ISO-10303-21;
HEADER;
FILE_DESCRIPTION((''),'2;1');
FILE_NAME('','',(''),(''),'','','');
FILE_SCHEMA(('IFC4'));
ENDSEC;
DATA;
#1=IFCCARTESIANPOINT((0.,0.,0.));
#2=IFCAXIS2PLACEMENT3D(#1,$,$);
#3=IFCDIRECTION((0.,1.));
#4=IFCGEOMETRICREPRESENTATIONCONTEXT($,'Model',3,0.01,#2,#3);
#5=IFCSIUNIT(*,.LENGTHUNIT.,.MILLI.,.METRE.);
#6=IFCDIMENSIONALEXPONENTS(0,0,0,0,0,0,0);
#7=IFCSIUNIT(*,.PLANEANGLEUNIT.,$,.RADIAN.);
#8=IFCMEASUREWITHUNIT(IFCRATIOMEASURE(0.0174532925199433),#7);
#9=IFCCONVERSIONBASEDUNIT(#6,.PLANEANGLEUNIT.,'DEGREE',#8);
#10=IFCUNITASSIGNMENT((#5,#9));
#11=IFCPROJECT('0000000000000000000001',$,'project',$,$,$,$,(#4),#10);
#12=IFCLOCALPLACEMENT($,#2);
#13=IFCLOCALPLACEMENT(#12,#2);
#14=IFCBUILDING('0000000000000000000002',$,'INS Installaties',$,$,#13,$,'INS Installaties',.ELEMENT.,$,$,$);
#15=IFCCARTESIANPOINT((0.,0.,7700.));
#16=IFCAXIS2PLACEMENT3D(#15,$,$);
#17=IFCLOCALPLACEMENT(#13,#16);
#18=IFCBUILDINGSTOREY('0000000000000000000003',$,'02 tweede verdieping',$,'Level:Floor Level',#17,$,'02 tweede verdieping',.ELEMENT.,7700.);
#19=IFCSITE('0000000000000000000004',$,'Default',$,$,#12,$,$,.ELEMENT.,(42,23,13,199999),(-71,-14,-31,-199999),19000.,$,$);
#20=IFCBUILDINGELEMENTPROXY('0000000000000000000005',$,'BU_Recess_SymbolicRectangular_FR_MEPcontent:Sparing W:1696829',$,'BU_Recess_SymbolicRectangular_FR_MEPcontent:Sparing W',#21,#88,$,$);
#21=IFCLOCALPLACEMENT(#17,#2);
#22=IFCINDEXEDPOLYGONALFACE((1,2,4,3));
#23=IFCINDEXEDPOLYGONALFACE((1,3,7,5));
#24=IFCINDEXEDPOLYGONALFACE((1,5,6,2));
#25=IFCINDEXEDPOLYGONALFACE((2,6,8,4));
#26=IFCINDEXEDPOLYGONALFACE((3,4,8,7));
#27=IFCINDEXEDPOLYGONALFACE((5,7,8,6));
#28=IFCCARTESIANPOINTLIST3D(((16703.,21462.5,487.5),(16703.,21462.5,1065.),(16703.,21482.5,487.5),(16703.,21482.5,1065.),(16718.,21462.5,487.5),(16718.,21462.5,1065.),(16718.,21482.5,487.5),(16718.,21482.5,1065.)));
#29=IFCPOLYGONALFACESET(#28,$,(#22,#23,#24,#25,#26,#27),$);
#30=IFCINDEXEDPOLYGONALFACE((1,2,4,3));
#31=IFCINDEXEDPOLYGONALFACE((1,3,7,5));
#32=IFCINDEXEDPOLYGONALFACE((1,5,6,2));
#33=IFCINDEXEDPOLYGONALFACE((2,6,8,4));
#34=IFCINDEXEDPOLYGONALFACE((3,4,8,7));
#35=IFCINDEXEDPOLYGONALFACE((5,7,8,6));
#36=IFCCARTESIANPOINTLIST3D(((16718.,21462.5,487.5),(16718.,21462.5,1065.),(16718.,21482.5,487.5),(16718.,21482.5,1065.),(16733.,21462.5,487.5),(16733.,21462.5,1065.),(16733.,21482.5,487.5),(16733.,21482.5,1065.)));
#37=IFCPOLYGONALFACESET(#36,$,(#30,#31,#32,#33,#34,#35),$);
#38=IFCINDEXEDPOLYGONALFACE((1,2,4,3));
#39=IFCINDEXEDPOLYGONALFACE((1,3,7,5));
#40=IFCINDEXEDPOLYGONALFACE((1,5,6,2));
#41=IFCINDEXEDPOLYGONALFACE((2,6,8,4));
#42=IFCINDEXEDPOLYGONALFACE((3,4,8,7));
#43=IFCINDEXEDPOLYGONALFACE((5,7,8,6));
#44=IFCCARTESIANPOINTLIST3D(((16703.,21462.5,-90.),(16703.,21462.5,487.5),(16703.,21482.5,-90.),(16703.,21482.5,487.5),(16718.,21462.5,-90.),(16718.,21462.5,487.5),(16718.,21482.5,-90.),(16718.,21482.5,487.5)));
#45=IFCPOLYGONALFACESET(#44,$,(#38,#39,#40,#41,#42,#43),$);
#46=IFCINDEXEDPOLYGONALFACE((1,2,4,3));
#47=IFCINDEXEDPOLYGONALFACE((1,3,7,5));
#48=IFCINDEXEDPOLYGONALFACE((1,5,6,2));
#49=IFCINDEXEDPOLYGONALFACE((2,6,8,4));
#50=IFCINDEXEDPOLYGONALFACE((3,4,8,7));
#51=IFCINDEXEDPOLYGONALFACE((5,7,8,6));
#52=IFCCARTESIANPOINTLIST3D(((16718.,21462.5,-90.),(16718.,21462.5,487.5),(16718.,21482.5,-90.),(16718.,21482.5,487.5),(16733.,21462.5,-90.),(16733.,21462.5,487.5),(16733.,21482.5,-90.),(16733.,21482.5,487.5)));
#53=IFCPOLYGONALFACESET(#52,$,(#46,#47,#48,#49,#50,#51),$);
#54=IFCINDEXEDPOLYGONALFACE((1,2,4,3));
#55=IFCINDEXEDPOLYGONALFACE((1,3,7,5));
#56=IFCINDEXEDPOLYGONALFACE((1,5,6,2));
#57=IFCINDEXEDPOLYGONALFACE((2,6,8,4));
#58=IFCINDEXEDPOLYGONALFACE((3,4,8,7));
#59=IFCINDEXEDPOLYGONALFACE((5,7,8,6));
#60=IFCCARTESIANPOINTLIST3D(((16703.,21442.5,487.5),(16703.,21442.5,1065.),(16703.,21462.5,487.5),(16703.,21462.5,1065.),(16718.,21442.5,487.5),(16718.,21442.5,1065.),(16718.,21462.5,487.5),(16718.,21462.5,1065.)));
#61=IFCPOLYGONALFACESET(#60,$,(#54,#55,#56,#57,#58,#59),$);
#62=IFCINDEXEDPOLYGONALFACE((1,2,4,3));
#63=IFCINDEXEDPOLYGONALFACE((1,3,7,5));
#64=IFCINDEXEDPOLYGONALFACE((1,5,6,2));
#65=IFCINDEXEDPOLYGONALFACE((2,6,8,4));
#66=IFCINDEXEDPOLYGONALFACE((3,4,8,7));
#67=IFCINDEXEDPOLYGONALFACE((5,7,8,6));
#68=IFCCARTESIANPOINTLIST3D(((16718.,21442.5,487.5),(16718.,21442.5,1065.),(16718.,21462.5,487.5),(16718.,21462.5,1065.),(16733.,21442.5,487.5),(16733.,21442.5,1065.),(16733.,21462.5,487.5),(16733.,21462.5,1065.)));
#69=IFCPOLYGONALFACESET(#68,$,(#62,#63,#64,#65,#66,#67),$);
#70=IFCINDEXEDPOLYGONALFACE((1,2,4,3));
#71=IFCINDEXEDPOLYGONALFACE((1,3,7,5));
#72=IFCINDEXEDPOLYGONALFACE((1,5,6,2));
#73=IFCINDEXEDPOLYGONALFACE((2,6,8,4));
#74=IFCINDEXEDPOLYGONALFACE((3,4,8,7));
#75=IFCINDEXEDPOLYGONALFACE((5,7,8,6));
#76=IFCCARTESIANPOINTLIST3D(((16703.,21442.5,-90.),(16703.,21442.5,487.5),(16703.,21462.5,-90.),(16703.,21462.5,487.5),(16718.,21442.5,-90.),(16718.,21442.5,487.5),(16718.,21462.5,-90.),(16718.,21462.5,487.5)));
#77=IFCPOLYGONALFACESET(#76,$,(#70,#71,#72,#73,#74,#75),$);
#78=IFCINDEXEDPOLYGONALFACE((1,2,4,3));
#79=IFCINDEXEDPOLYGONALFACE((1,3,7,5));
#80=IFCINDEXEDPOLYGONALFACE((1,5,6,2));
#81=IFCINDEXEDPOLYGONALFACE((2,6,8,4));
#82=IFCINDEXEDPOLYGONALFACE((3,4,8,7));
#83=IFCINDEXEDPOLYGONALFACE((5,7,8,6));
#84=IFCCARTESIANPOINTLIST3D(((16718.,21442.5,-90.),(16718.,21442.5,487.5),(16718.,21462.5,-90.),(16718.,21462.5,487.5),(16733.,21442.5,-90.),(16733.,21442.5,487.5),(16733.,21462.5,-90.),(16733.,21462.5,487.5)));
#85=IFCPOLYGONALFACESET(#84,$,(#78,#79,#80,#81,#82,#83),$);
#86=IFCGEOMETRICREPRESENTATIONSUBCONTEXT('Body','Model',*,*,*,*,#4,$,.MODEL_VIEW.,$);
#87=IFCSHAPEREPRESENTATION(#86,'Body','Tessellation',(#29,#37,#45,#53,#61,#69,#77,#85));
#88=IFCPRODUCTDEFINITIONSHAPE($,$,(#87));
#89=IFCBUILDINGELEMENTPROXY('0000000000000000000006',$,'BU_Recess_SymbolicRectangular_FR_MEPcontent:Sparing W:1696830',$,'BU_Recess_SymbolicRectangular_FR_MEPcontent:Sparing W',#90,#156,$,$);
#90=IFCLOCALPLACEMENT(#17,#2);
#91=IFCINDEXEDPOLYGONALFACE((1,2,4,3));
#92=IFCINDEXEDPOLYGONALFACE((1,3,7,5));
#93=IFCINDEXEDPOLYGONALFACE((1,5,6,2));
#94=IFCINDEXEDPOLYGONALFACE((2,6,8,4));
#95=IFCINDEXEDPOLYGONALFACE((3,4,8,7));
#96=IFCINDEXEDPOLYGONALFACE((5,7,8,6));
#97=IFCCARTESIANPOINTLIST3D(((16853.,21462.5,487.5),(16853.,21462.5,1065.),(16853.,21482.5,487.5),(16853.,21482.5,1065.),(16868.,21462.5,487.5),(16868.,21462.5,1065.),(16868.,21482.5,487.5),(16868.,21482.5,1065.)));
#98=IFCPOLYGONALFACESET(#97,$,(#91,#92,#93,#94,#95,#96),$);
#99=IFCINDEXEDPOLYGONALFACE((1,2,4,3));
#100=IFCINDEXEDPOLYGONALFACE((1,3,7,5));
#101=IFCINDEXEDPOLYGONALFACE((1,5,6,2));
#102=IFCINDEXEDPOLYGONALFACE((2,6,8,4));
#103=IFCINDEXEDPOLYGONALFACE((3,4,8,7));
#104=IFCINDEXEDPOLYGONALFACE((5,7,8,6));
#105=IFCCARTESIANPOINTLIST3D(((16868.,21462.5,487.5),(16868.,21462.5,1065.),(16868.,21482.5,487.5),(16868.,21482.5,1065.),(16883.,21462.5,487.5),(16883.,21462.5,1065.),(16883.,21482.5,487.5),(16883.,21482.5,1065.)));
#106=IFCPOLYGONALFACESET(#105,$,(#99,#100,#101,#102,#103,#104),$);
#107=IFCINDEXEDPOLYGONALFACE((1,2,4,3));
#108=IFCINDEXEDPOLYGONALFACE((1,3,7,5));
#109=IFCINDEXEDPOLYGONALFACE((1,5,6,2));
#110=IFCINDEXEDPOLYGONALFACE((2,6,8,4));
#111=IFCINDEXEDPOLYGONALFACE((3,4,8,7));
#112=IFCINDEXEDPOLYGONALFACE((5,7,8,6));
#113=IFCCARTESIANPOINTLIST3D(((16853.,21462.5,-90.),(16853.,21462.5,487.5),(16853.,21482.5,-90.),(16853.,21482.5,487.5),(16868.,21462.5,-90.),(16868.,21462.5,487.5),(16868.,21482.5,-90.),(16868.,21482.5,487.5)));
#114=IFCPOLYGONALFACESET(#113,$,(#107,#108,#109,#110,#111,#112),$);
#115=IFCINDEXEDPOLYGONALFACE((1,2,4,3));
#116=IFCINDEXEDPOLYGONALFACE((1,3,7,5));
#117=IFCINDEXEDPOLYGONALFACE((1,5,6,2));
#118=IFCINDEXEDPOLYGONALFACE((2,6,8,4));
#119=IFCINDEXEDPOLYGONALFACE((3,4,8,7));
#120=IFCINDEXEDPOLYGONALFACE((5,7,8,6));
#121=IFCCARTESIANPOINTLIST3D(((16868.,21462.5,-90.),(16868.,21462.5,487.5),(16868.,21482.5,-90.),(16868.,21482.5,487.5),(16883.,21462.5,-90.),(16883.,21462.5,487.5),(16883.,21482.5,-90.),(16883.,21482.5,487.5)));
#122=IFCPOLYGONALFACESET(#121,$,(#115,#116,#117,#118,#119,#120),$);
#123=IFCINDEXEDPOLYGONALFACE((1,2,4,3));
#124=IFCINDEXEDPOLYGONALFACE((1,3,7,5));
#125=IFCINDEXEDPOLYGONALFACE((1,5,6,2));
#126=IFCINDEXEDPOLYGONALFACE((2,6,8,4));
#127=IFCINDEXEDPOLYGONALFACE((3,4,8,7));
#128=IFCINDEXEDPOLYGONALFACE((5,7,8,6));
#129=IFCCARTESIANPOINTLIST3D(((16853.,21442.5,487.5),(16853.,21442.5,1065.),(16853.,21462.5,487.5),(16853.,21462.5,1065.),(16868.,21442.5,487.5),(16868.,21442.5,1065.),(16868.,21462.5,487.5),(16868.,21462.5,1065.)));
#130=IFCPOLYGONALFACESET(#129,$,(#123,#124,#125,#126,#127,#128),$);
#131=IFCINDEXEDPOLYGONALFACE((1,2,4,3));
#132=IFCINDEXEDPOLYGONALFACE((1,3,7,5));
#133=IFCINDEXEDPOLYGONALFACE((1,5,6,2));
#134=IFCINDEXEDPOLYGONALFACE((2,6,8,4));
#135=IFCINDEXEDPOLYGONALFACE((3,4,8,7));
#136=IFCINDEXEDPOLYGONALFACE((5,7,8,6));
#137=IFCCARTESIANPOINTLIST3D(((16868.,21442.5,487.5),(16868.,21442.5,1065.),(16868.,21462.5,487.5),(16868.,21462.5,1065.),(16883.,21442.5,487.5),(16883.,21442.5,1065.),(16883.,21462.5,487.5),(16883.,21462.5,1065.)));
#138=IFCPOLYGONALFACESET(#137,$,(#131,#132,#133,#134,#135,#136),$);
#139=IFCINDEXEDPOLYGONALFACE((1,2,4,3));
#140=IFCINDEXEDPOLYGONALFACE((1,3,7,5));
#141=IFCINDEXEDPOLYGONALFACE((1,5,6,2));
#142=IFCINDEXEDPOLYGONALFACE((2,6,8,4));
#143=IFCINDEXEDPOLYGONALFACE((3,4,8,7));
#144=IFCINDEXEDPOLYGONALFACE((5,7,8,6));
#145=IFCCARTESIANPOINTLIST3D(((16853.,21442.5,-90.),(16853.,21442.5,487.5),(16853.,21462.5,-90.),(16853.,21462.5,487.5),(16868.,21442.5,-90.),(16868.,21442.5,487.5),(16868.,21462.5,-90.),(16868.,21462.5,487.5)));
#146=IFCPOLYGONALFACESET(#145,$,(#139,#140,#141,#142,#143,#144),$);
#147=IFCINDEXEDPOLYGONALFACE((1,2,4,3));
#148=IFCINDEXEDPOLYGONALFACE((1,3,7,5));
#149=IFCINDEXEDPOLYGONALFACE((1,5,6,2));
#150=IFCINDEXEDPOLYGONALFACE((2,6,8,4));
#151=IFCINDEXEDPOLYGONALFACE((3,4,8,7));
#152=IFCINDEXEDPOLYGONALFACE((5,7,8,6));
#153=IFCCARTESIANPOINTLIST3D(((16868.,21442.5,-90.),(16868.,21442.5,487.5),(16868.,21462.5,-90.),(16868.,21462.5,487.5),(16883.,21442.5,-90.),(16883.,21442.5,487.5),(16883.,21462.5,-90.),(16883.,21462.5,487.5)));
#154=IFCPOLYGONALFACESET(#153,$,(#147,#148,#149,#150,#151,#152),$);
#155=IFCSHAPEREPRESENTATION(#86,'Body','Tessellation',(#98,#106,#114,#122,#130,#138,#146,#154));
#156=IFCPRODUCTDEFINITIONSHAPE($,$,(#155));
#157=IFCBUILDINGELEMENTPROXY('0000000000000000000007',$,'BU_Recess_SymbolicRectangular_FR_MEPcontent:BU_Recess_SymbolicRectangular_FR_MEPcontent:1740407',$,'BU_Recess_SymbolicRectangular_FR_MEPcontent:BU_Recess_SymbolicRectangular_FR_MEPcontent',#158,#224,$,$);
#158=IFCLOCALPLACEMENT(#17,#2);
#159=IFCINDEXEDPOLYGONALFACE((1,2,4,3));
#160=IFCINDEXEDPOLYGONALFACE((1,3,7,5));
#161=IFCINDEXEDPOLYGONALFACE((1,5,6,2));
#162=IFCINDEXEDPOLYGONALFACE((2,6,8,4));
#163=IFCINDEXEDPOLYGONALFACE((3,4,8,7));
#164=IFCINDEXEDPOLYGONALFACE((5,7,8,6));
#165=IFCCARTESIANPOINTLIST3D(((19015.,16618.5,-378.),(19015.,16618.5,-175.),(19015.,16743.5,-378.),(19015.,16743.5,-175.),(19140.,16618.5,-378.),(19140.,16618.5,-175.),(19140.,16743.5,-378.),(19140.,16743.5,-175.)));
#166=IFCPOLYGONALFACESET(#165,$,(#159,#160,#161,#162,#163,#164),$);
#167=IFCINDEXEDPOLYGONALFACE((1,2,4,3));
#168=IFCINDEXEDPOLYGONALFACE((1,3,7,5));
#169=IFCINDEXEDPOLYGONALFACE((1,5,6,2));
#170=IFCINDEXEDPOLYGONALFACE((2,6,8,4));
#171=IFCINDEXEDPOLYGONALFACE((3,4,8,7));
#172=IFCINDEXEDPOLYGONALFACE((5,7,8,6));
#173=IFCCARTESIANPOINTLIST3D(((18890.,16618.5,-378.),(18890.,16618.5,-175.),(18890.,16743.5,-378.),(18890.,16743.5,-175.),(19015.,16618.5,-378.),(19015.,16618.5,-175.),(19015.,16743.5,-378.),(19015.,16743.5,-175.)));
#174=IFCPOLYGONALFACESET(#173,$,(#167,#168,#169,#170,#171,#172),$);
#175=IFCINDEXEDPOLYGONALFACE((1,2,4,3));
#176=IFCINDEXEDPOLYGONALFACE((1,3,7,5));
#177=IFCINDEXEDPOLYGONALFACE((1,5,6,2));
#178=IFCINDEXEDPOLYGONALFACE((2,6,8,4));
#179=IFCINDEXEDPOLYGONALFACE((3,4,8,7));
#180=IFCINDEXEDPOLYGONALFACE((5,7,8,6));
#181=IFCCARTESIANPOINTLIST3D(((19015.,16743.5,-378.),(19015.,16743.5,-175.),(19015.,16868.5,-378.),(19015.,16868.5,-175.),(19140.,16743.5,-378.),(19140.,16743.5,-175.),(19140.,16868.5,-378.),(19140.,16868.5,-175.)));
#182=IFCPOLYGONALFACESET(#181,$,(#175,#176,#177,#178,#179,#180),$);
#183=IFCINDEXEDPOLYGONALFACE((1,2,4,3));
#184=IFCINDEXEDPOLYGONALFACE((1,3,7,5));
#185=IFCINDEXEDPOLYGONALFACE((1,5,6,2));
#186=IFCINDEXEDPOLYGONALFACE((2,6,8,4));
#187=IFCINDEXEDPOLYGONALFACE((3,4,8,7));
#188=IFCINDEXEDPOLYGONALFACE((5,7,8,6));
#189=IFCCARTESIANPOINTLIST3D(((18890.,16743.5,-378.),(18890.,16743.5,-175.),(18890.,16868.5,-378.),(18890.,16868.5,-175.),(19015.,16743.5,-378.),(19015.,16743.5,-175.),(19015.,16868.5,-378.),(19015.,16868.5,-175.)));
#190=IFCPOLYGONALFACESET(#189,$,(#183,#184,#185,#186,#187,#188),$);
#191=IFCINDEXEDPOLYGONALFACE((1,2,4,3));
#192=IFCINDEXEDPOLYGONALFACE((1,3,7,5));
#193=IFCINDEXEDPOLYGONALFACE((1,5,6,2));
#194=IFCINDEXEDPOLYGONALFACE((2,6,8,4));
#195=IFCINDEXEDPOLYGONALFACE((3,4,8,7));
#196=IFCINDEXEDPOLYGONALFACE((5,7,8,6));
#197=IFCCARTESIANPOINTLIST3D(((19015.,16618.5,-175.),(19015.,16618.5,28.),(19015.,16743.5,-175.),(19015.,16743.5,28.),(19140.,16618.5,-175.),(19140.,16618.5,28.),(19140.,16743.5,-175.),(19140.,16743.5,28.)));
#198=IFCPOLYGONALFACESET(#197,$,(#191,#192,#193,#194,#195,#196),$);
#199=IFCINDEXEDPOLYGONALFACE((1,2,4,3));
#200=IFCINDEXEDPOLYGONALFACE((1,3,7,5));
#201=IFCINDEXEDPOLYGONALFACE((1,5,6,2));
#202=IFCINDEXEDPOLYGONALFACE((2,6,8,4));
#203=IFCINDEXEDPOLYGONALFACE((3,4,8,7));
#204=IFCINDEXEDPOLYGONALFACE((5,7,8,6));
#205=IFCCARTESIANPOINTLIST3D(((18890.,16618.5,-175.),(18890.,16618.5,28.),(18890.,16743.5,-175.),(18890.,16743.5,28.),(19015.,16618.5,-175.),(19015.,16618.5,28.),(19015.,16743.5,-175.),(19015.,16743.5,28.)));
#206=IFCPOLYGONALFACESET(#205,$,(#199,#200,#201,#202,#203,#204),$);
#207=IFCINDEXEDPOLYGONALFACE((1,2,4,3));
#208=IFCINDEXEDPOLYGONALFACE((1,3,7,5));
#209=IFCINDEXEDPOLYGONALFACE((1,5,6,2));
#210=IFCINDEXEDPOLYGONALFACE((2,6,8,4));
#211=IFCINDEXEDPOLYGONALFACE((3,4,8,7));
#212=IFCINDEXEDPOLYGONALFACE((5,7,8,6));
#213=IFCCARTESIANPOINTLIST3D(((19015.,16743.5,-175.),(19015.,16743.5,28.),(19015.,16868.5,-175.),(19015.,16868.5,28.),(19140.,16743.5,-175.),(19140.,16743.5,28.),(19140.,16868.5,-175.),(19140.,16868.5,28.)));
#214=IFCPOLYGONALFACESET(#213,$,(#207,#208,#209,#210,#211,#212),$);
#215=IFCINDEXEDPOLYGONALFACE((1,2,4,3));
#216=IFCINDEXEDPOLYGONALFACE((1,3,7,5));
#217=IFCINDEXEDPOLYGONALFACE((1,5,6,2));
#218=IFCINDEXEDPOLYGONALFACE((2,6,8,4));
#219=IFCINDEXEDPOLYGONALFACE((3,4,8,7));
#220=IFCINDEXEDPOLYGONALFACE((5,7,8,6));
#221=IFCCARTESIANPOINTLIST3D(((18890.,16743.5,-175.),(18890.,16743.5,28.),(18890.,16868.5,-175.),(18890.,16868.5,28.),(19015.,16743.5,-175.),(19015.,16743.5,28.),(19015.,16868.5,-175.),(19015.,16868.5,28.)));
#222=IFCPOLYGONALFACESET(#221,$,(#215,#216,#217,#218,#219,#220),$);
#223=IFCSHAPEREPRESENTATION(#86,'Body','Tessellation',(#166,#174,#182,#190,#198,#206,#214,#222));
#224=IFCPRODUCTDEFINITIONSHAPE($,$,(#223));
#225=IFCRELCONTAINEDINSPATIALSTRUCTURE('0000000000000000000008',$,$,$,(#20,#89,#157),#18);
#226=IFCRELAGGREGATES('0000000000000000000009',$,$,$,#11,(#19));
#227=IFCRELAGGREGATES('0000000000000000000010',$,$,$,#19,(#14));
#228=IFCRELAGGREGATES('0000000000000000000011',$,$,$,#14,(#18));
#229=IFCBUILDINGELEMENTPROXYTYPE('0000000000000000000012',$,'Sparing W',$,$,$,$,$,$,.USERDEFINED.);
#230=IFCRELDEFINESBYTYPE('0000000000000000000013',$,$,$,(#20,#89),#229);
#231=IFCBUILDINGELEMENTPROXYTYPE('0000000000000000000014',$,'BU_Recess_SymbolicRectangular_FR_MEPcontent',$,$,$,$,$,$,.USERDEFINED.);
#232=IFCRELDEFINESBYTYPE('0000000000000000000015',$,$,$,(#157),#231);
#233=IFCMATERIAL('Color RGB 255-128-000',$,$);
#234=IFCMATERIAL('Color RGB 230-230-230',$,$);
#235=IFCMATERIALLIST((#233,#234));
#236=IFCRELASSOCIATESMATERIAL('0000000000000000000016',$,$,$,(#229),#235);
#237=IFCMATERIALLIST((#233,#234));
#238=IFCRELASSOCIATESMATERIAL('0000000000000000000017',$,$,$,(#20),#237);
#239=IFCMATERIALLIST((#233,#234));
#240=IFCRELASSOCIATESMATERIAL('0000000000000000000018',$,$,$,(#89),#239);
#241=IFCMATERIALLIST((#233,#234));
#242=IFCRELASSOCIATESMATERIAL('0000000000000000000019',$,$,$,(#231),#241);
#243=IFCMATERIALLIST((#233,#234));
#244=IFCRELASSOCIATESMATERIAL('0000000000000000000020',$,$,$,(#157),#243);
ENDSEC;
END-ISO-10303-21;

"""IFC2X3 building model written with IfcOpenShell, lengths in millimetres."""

from ifc_helpers import new_model, entity, si_unit, converted_unit, direction, frame, frame_2d, origin, origin_2d_with_axis, place, context, subcontext, project, spatial, rectangle, extrude, source, transform, mapped, material, material_list, type_object, type_shapes, element, save


model = new_model("IFC2X3")

# Units and contexts
model_context = context("Model", 3, precision=0.01, world=origin(), true_north=direction((0.0, 1.0)))
body_context = subcontext(model_context, "Body", "Model", "MODEL_VIEW")
ifc_project = project(units=[si_unit("LENGTHUNIT", "METRE", prefix="MILLI"), converted_unit("PLANEANGLEUNIT", "DEGREE", entity("IfcRatioMeasure", 0.0174532925199433), si_unit("PLANEANGLEUNIT", "RADIAN"), dimensions=[0, 0, 0, 0, 0, 0, 0])], contexts=[model_context])

# Site, building, storey
site_placement = place(None, origin())
site = spatial("IfcSite", under=ifc_project, at=site_placement, Name="Default", CompositionType="ELEMENT", RefLatitude=(42, 23, 13, 199999), RefLongitude=(-71, -14, -31, -199999), RefElevation=19000.0)
building_placement = place(site_placement, origin())
building = spatial("IfcBuilding", under=site, at=building_placement, Name="INS Installaties", LongName="INS Installaties", CompositionType="ELEMENT")
storey_placement = place(building_placement, frame((0.0, 0.0, 7700.0)))
storey = spatial("IfcBuildingStorey", under=building, at=storey_placement, Name="02 tweede verdieping", ObjectType="Level:Floor Level", LongName="02 tweede verdieping", CompositionType="ELEMENT", Elevation=7700.0)

# Building element proxies
ifc_material_1 = material(Name="Color RGB 255-128-000")
ifc_material_2 = material(Name="Color RGB 230-230-230")
ifc_material_list_1 = material_list([ifc_material_1, ifc_material_2])
ifc_material_list_2 = material_list([ifc_material_1, ifc_material_2])
building_element_proxy_type_1 = type_object("IfcBuildingElementProxyType", Name="Sparing W", PredefinedType="USERDEFINED", material=ifc_material_list_2)
shared_shape_1 = source(origin(), body_context, "Body", "SweptSolid", [
    extrude(rectangle(XDim=20.0, YDim=15.0, at=frame_2d((0.0, 0.0), x_axis=(1.0, 0.0))), frame((7.5, -27.0, 0.0), z_axis=(0.0, 0.0, 1.0), x_axis=(0.0, -1.0, 0.0)), (0.0, 0.0, 1.0), 577.5),
    extrude(rectangle(XDim=20.0, YDim=15.0, at=frame_2d((0.0, 0.0), x_axis=(1.0, 0.0))), frame((-7.5, -27.0, 0.0), z_axis=(0.0, 0.0, 1.0), x_axis=(0.0, -1.0, 0.0)), (0.0, 0.0, 1.0), 577.5),
    extrude(rectangle(XDim=20.0, YDim=15.0, at=frame_2d((0.0, 0.0), x_axis=(1.0, 0.0))), frame((7.5, -27.0, -577.5), z_axis=(0.0, 0.0, 1.0), x_axis=(0.0, -1.0, 0.0)), (0.0, 0.0, 1.0), 577.5),
    extrude(rectangle(XDim=20.0, YDim=15.0, at=frame_2d((0.0, 0.0), x_axis=(1.0, 0.0))), frame((-7.5, -27.0, -577.5), z_axis=(0.0, 0.0, 1.0), x_axis=(0.0, -1.0, 0.0)), (0.0, 0.0, 1.0), 577.5),
    extrude(rectangle(XDim=20.0, YDim=15.0, at=frame_2d((0.0, 0.0), x_axis=(1.0, 0.0))), frame((7.5, -7.0, 0.0), z_axis=(0.0, 0.0, 1.0), x_axis=(0.0, -1.0, 0.0)), (0.0, 0.0, 1.0), 577.5),
    extrude(rectangle(XDim=20.0, YDim=15.0, at=frame_2d((0.0, 0.0), x_axis=(1.0, 0.0))), frame((-7.5, -7.0, 0.0), z_axis=(0.0, 0.0, 1.0), x_axis=(0.0, -1.0, 0.0)), (0.0, 0.0, 1.0), 577.5),
    extrude(rectangle(XDim=20.0, YDim=15.0, at=origin_2d_with_axis()), frame((7.5, -7.0, -577.5), z_axis=(0.0, 0.0, 1.0), x_axis=(0.0, -1.0, 0.0)), (0.0, 0.0, 1.0), 577.5),
    extrude(rectangle(XDim=20.0, YDim=15.0, at=frame_2d((0.0, 0.0), x_axis=(1.0, 0.0))), frame((-7.5, -7.0, -577.5), z_axis=(0.0, 0.0, 1.0), x_axis=(0.0, -1.0, 0.0)), (0.0, 0.0, 1.0), 577.5),
])
type_shapes(building_element_proxy_type_1, [shared_shape_1])
proxy_1_placement = place(storey_placement, frame((16718.0, 21445.5, 487.5), z_axis=(0.0, 0.0, 1.0), x_axis=(-1.0, 0.0, 0.0)))
element("IfcBuildingElementProxy", 1, at=proxy_1_placement, inside=storey, type_object=building_element_proxy_type_1, material=ifc_material_list_1, Name="BU_Recess_SymbolicRectangular_FR_MEPcontent:Sparing W:1696829", ObjectType="BU_Recess_SymbolicRectangular_FR_MEPcontent:Sparing W", context=body_context, shape_type="MappedRepresentation", body=[
    mapped(shared_shape_1, transform((0.0, 0.0, 0.0), scale=1.0)),
])
ifc_material_list_3 = material_list([ifc_material_1, ifc_material_2])
proxy_2_placement = place(storey_placement, frame((16868.0, 21445.5, 487.5), z_axis=(0.0, 0.0, 1.0), x_axis=(-1.0, 0.0, 0.0)))
element("IfcBuildingElementProxy", 2, at=proxy_2_placement, inside=storey, type_object=building_element_proxy_type_1, material=ifc_material_list_3, Name="BU_Recess_SymbolicRectangular_FR_MEPcontent:Sparing W:1696830", ObjectType="BU_Recess_SymbolicRectangular_FR_MEPcontent:Sparing W", context=body_context, shape_type="MappedRepresentation", body=[
    mapped(shared_shape_1, transform((0.0, 0.0, 0.0), scale=1.0)),
])
ifc_material_list_4 = material_list([ifc_material_1, ifc_material_2])
ifc_material_list_5 = material_list([ifc_material_1, ifc_material_2])
building_element_proxy_type_2 = type_object("IfcBuildingElementProxyType", Name="BU_Recess_SymbolicRectangular_FR_MEPcontent", PredefinedType="USERDEFINED", material=ifc_material_list_5)
shared_shape_2 = source(origin(), body_context, "Body", "SweptSolid", [
    extrude(rectangle(XDim=125.0, YDim=125.0, at=frame_2d((0.0, 0.0), x_axis=(1.0, 0.0))), frame((62.5, -62.5, -403.0)), (0.0, 0.0, 1.0), 203.0),
    extrude(rectangle(XDim=125.0, YDim=125.0, at=origin_2d_with_axis()), frame((-62.5, -62.5, -403.0), z_axis=(0.0, 0.0, 1.0), x_axis=(0.0, 1.0, 0.0)), (0.0, 0.0, 1.0), 203.0),
    extrude(rectangle(XDim=125.0, YDim=125.0, at=origin_2d_with_axis()), frame((62.5, 62.5, -403.0), z_axis=(0.0, 0.0, 1.0), x_axis=(0.0, -1.0, 0.0)), (0.0, 0.0, 1.0), 203.0),
    extrude(rectangle(XDim=125.0, YDim=125.0, at=origin_2d_with_axis()), frame((-62.5, 62.5, -403.0), z_axis=(0.0, 0.0, 1.0), x_axis=(-1.0, 0.0, 0.0)), (0.0, 0.0, 1.0), 203.0),
    extrude(rectangle(XDim=125.0, YDim=125.0, at=frame_2d((0.0, 0.0), x_axis=(1.0, 0.0))), frame((62.5, -62.5, -200.0)), (0.0, 0.0, 1.0), 203.0),
    extrude(rectangle(XDim=125.0, YDim=125.0, at=frame_2d((0.0, 0.0), x_axis=(1.0, 0.0))), frame((-62.5, -62.5, -200.0), z_axis=(0.0, 0.0, 1.0), x_axis=(0.0, 1.0, 0.0)), (0.0, 0.0, 1.0), 203.0),
    extrude(rectangle(XDim=125.0, YDim=125.0, at=frame_2d((0.0, 0.0), x_axis=(1.0, 0.0))), frame((62.5, 62.5, -200.0), z_axis=(0.0, 0.0, 1.0), x_axis=(0.0, -1.0, 0.0)), (0.0, 0.0, 1.0), 203.0),
    extrude(rectangle(XDim=125.0, YDim=125.0, at=origin_2d_with_axis()), frame((-62.5, 62.5, -200.0), z_axis=(0.0, 0.0, 1.0), x_axis=(-1.0, 0.0, 0.0)), (0.0, 0.0, 1.0), 203.0),
])
type_shapes(building_element_proxy_type_2, [shared_shape_2])
proxy_3_placement = place(storey_placement, frame((19015.0, 16743.5, 25.0)))
element("IfcBuildingElementProxy", 3, at=proxy_3_placement, inside=storey, type_object=building_element_proxy_type_2, material=ifc_material_list_4, Name="BU_Recess_SymbolicRectangular_FR_MEPcontent:BU_Recess_SymbolicRectangular_FR_MEPcontent:1740407", ObjectType="BU_Recess_SymbolicRectangular_FR_MEPcontent:BU_Recess_SymbolicRectangular_FR_MEPcontent", context=body_context, shape_type="MappedRepresentation", body=[
    mapped(shared_shape_2, transform((0.0, 0.0, 0.0), scale=1.0)),
])

save(model, "model.ifc")
